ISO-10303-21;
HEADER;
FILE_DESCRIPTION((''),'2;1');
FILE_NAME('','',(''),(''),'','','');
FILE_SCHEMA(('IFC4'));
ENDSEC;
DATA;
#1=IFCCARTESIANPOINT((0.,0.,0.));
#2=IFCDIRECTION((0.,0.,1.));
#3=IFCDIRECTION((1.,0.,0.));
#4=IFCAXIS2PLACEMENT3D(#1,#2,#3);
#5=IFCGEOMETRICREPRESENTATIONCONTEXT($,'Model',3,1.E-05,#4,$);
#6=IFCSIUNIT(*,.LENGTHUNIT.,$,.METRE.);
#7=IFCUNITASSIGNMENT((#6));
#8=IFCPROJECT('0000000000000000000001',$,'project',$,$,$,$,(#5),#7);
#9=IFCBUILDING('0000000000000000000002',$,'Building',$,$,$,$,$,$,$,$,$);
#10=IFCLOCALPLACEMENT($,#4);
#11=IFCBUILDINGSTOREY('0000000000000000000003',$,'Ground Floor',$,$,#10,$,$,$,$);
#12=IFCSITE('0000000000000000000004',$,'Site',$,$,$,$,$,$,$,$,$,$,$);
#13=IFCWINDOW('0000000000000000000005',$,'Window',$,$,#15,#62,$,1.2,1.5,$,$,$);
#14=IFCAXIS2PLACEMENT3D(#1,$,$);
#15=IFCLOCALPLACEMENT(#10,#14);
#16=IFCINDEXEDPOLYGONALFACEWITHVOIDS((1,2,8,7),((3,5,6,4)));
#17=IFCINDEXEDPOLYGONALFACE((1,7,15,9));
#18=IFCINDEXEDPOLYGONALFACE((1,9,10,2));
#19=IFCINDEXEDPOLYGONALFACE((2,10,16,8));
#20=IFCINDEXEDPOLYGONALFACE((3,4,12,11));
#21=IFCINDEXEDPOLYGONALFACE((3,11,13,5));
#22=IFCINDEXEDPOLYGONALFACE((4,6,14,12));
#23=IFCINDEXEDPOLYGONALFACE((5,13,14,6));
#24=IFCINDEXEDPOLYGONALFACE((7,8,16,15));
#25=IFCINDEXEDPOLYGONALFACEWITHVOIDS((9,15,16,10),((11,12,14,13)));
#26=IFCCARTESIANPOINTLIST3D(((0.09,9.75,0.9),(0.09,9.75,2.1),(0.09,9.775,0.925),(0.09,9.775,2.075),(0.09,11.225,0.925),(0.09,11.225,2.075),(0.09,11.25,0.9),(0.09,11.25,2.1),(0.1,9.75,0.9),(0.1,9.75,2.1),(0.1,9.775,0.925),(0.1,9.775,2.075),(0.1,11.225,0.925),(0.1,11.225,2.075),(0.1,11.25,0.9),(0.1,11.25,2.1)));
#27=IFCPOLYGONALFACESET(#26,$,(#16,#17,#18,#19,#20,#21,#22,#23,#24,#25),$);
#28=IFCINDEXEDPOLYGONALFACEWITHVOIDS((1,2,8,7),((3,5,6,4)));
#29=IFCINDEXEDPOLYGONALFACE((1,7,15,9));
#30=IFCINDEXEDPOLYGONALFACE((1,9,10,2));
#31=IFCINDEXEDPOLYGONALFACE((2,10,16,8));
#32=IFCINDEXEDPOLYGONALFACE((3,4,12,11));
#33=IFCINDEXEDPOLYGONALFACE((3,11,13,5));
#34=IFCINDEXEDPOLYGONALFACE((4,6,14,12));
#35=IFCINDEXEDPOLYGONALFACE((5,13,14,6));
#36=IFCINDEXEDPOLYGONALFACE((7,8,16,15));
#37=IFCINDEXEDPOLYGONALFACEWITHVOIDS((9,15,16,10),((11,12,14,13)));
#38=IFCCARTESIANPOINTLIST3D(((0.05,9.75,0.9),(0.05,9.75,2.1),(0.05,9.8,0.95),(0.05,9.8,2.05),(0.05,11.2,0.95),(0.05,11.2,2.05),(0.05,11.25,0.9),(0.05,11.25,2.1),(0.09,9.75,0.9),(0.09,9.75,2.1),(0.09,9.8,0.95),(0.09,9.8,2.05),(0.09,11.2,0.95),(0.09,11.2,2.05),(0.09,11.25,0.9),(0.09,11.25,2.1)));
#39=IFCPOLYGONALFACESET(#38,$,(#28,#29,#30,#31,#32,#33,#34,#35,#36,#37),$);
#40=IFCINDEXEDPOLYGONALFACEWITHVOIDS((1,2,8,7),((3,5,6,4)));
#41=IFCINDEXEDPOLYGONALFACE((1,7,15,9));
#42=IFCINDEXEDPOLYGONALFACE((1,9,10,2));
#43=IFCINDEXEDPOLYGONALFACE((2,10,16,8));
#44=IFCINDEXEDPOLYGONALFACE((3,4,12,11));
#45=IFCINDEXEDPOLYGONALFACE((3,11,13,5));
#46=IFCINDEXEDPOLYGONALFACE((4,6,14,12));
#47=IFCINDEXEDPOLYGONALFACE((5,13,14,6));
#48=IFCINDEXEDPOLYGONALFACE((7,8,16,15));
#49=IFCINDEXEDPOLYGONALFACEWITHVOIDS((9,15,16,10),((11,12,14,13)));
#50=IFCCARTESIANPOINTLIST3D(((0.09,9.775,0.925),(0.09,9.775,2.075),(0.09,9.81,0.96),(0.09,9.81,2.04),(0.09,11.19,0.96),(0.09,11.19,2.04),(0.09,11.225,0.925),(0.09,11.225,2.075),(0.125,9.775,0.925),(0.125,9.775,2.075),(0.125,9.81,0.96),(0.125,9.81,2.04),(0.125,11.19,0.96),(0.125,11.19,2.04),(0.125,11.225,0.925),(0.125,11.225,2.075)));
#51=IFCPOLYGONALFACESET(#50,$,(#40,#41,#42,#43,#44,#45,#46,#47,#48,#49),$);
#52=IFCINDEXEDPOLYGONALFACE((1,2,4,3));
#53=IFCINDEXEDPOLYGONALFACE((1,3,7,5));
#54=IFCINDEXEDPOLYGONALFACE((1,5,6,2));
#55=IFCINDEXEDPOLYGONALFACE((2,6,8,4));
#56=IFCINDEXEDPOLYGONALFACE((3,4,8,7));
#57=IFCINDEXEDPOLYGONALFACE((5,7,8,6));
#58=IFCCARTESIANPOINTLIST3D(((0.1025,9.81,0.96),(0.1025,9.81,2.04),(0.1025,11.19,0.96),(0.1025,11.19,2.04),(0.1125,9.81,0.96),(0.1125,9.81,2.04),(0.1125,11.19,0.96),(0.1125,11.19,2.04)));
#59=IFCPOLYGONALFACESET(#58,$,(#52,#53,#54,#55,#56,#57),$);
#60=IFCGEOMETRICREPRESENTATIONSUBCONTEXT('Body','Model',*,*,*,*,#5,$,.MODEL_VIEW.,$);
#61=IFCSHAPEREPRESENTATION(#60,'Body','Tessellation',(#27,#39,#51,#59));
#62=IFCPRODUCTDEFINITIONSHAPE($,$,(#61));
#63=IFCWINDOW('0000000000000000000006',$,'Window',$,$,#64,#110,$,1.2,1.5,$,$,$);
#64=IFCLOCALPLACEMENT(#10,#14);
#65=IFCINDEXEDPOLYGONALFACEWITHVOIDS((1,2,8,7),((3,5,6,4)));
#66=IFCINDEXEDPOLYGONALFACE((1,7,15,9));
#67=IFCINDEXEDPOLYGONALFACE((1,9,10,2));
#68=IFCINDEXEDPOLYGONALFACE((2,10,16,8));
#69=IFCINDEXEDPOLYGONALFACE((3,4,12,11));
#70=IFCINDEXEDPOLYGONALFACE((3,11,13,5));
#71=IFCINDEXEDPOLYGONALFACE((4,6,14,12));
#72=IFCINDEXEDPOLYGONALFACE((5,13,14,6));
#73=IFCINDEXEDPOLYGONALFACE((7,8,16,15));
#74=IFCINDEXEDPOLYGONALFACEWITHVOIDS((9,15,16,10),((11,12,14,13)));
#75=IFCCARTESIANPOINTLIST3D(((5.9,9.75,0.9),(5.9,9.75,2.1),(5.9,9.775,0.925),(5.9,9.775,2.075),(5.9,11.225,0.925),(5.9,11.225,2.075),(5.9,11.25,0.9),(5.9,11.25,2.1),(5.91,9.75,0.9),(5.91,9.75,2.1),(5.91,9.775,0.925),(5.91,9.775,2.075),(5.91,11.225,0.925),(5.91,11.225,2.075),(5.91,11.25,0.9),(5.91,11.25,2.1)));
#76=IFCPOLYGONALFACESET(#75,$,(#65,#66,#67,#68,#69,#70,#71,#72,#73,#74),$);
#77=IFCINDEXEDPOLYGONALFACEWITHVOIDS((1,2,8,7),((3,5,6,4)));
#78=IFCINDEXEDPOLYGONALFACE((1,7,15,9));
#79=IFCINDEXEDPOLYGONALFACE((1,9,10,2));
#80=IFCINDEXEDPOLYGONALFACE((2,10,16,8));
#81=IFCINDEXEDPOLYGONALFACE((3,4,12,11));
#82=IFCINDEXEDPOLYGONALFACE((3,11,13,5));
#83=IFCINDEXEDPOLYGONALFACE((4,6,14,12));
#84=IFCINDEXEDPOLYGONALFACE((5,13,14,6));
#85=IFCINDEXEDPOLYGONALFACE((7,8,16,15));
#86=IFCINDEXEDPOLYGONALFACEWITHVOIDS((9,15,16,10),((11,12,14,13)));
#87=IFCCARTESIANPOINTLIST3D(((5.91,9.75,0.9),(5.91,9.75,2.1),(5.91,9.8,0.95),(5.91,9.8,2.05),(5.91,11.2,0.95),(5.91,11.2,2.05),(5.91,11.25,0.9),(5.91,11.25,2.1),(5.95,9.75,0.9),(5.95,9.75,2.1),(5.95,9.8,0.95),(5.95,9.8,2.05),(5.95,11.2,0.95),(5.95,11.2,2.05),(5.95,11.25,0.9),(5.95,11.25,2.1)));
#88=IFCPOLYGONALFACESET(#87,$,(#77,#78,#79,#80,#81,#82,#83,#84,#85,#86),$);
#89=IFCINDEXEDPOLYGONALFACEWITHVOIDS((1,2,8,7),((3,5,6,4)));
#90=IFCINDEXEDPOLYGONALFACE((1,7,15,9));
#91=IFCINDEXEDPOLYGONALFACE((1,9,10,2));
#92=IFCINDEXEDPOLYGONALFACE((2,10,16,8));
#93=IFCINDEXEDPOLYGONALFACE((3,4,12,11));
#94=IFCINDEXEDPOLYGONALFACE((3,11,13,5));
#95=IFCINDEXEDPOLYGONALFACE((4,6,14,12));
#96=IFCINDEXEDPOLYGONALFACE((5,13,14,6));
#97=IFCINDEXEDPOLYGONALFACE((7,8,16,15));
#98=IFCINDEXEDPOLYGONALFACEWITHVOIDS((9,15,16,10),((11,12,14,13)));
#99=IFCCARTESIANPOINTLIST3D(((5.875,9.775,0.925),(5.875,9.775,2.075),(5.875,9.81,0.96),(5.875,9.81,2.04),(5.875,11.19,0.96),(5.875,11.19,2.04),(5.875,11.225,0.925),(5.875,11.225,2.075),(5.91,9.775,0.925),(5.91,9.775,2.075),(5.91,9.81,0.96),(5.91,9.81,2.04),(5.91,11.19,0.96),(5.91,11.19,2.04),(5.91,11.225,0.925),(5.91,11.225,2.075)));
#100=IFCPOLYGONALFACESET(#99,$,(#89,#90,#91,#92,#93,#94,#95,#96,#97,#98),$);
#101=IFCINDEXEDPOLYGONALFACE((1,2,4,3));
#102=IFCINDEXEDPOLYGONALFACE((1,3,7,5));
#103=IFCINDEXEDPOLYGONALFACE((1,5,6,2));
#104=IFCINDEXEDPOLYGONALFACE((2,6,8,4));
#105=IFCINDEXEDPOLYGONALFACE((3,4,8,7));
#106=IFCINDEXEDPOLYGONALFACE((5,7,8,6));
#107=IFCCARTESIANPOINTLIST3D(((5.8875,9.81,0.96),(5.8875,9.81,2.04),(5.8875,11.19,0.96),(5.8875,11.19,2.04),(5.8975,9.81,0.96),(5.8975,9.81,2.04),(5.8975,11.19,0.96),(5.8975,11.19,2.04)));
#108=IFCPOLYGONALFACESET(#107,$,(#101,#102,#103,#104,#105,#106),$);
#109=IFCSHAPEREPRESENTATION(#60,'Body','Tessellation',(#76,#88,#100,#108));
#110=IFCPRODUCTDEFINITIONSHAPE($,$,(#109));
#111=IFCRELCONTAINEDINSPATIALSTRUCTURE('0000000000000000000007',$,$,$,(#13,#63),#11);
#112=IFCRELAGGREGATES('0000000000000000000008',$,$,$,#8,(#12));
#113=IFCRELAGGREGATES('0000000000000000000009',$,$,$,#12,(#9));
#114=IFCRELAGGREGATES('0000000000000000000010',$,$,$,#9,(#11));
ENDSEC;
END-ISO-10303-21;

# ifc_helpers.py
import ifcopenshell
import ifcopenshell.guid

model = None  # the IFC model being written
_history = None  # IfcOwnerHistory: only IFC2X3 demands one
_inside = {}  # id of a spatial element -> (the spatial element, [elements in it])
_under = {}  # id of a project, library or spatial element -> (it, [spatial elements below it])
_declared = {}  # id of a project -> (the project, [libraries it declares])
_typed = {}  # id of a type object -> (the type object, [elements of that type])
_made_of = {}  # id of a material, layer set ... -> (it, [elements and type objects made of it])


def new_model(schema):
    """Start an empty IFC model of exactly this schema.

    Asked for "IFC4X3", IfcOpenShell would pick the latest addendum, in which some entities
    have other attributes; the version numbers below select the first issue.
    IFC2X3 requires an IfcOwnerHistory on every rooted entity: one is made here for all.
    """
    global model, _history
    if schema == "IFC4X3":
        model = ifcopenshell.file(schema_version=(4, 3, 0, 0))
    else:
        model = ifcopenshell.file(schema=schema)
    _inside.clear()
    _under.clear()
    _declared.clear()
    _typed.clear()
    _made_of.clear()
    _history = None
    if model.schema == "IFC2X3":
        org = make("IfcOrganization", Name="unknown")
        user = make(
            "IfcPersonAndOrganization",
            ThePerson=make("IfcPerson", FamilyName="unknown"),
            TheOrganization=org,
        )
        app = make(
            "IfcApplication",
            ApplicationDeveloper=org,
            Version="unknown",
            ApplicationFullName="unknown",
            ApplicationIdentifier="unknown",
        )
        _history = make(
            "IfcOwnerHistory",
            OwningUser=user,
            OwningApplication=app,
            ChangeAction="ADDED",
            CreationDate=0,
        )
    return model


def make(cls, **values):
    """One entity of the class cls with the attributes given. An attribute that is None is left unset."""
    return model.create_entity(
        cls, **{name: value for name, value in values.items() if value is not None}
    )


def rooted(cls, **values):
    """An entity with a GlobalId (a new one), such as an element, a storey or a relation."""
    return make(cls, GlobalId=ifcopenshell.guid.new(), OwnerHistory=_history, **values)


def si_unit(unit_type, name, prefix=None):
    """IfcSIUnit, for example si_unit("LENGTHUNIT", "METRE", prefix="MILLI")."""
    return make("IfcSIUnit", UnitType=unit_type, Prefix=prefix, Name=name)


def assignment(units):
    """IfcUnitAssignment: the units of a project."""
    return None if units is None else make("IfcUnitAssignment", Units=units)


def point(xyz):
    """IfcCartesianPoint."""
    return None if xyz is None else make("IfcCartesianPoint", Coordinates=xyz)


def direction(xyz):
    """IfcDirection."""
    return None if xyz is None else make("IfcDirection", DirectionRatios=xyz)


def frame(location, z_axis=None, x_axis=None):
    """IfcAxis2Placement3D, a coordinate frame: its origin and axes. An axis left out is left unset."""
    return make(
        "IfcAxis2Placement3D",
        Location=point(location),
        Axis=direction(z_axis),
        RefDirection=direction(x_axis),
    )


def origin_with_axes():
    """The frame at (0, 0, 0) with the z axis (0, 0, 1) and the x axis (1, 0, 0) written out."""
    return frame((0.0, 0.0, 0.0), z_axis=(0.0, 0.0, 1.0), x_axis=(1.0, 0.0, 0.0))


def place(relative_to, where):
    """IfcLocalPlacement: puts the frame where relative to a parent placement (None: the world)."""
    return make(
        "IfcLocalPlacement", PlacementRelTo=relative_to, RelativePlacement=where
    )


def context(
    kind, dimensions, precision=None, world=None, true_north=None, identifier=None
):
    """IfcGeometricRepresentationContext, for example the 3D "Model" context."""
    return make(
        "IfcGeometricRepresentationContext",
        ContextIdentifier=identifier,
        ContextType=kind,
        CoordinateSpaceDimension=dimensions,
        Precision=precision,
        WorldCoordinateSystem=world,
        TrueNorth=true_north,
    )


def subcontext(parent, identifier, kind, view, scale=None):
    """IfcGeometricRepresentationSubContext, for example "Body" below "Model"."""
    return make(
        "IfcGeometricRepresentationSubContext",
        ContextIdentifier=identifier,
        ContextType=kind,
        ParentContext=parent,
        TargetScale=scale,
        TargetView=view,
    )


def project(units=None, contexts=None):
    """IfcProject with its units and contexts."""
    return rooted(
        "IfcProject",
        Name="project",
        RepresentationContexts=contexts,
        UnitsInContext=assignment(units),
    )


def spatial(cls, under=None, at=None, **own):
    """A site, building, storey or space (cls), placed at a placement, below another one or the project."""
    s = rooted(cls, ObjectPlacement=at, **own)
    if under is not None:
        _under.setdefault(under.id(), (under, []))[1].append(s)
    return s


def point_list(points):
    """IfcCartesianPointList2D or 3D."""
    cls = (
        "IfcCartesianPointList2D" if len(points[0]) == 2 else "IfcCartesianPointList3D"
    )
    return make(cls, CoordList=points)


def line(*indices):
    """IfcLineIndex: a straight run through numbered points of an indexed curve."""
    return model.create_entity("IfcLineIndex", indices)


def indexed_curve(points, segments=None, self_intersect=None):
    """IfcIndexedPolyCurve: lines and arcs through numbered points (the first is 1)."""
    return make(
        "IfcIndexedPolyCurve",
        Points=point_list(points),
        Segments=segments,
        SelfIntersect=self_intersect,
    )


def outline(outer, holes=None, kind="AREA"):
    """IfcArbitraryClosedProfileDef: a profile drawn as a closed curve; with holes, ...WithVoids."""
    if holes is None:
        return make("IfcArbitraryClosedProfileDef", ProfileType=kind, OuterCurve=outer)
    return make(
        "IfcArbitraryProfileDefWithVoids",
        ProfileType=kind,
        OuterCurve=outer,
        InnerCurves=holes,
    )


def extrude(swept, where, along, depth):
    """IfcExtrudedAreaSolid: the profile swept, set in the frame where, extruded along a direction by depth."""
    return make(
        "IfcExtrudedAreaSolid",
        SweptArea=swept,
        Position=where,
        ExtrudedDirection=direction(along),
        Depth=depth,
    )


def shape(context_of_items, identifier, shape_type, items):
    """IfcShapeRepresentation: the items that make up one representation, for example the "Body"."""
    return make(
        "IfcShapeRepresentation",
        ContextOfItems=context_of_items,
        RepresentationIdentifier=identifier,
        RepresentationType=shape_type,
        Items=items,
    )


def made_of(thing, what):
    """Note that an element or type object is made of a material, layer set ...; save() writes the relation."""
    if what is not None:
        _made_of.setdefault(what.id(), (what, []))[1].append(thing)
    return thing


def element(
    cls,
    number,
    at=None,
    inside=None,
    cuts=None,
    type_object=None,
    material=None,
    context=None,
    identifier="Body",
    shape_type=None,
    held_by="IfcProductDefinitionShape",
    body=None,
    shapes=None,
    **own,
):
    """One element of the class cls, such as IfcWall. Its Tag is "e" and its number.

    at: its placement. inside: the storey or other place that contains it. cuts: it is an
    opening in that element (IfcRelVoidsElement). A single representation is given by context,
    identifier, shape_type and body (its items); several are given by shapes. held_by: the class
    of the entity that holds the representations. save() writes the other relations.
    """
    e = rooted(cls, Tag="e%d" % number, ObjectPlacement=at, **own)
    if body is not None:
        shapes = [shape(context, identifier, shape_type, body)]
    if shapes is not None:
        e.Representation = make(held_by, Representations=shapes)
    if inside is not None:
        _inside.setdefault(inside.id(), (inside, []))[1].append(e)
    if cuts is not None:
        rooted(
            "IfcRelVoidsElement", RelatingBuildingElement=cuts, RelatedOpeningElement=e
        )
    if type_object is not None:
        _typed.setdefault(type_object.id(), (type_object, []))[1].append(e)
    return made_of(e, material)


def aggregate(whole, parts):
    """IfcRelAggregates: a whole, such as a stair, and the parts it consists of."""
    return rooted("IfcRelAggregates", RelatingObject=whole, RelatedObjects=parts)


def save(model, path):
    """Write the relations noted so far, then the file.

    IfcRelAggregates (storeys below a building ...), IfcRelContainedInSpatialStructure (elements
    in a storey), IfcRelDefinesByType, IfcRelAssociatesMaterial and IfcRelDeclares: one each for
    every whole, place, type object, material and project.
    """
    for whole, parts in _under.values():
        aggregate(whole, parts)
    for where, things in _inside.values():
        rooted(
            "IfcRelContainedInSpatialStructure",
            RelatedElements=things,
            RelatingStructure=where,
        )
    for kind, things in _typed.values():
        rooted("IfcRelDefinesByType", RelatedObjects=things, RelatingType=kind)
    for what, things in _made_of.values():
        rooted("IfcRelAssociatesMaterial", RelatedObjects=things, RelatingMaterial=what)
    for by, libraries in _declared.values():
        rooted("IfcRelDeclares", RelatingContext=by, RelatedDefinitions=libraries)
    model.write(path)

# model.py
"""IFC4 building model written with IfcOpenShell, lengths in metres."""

from ifc_helpers import new_model, si_unit, frame, origin_with_axes, place, context, subcontext, project, spatial, line, indexed_curve, outline, extrude, element, save


model = new_model("IFC4")

# Units and contexts
model_context = context("Model", 3, precision=1e-05, world=origin_with_axes())
body_context = subcontext(model_context, "Body", "Model", "MODEL_VIEW")
ifc_project = project(units=[si_unit("LENGTHUNIT", "METRE")], contexts=[model_context])

# Site, building, storey
site = spatial("IfcSite", under=ifc_project, Name="Site")
building = spatial("IfcBuilding", under=site, Name="Building")
storey_placement = place(None, origin_with_axes())
storey = spatial("IfcBuildingStorey", under=building, at=storey_placement, Name="Ground Floor")

# Windows
for number, where, z_axis, x_axis, name in (
    (1, (0.0, 11.25, 0.9), (0.0, 0.0, 1.0), (0.0, -1.0, 0.0), "Window"),
    (2, (6.0, 9.75, 0.9), (0.0, 0.0, 1.0), (0.0, 1.0, 0.0), "Window"),
):
    element("IfcWindow", number, at=place(storey_placement, frame(where, z_axis=z_axis, x_axis=x_axis)), inside=storey, Name=name, OverallHeight=1.2, OverallWidth=1.5, context=body_context, shape_type="SweptSolid", body=[
        extrude(outline(indexed_curve([(0.0, 0.0), (1.5, 0.0), (1.5, 1.2), (0.0, 1.2)], segments=[line(1, 2, 3, 4, 1)]), holes=[indexed_curve([(0.025, 0.025), (1.475, 0.025), (1.475, 1.175), (0.025, 1.175)], segments=[line(1, 2, 3, 4, 1)])]), frame((0.0, 0.09, 0.0), z_axis=(0.0, -1.0, 0.0), x_axis=(1.0, 0.0, 0.0)), (0.0, 0.0, -1.0), 0.01),
        extrude(outline(indexed_curve([(0.0, 0.0), (1.5, 0.0), (1.5, 1.2), (0.0, 1.2)], segments=[line(1, 2, 3, 4, 1)]), holes=[indexed_curve([(0.05, 0.05), (1.45, 0.05), (1.45, 1.15), (0.05, 1.15)], segments=[line(1, 2, 3, 4, 1)])]), frame((0.0, 0.05, 0.0), z_axis=(0.0, -1.0, 0.0), x_axis=(1.0, 0.0, 0.0)), (0.0, 0.0, -1.0), 0.04),
        extrude(outline(indexed_curve([(0.0, 0.0), (1.45, 0.0), (1.45, 1.15), (0.0, 1.15)], segments=[line(1, 2, 3, 4, 1)]), holes=[indexed_curve([(0.035, 0.035), (1.415, 0.035), (1.415, 1.115), (0.035, 1.115)], segments=[line(1, 2, 3, 4, 1)])]), frame((0.025, 0.09, 0.025), z_axis=(0.0, -1.0, 0.0), x_axis=(1.0, 0.0, 0.0)), (0.0, 0.0, -1.0), 0.035),
        extrude(outline(indexed_curve([(0.035, 0.035), (1.415, 0.035), (1.415, 1.115), (0.035, 1.115)], segments=[line(1, 2, 3, 4, 1)])), frame((0.025, 0.1025, 0.025), z_axis=(0.0, -1.0, 0.0), x_axis=(1.0, 0.0, 0.0)), (0.0, 0.0, -1.0), 0.01),
    ])

save(model, "model.ifc")
